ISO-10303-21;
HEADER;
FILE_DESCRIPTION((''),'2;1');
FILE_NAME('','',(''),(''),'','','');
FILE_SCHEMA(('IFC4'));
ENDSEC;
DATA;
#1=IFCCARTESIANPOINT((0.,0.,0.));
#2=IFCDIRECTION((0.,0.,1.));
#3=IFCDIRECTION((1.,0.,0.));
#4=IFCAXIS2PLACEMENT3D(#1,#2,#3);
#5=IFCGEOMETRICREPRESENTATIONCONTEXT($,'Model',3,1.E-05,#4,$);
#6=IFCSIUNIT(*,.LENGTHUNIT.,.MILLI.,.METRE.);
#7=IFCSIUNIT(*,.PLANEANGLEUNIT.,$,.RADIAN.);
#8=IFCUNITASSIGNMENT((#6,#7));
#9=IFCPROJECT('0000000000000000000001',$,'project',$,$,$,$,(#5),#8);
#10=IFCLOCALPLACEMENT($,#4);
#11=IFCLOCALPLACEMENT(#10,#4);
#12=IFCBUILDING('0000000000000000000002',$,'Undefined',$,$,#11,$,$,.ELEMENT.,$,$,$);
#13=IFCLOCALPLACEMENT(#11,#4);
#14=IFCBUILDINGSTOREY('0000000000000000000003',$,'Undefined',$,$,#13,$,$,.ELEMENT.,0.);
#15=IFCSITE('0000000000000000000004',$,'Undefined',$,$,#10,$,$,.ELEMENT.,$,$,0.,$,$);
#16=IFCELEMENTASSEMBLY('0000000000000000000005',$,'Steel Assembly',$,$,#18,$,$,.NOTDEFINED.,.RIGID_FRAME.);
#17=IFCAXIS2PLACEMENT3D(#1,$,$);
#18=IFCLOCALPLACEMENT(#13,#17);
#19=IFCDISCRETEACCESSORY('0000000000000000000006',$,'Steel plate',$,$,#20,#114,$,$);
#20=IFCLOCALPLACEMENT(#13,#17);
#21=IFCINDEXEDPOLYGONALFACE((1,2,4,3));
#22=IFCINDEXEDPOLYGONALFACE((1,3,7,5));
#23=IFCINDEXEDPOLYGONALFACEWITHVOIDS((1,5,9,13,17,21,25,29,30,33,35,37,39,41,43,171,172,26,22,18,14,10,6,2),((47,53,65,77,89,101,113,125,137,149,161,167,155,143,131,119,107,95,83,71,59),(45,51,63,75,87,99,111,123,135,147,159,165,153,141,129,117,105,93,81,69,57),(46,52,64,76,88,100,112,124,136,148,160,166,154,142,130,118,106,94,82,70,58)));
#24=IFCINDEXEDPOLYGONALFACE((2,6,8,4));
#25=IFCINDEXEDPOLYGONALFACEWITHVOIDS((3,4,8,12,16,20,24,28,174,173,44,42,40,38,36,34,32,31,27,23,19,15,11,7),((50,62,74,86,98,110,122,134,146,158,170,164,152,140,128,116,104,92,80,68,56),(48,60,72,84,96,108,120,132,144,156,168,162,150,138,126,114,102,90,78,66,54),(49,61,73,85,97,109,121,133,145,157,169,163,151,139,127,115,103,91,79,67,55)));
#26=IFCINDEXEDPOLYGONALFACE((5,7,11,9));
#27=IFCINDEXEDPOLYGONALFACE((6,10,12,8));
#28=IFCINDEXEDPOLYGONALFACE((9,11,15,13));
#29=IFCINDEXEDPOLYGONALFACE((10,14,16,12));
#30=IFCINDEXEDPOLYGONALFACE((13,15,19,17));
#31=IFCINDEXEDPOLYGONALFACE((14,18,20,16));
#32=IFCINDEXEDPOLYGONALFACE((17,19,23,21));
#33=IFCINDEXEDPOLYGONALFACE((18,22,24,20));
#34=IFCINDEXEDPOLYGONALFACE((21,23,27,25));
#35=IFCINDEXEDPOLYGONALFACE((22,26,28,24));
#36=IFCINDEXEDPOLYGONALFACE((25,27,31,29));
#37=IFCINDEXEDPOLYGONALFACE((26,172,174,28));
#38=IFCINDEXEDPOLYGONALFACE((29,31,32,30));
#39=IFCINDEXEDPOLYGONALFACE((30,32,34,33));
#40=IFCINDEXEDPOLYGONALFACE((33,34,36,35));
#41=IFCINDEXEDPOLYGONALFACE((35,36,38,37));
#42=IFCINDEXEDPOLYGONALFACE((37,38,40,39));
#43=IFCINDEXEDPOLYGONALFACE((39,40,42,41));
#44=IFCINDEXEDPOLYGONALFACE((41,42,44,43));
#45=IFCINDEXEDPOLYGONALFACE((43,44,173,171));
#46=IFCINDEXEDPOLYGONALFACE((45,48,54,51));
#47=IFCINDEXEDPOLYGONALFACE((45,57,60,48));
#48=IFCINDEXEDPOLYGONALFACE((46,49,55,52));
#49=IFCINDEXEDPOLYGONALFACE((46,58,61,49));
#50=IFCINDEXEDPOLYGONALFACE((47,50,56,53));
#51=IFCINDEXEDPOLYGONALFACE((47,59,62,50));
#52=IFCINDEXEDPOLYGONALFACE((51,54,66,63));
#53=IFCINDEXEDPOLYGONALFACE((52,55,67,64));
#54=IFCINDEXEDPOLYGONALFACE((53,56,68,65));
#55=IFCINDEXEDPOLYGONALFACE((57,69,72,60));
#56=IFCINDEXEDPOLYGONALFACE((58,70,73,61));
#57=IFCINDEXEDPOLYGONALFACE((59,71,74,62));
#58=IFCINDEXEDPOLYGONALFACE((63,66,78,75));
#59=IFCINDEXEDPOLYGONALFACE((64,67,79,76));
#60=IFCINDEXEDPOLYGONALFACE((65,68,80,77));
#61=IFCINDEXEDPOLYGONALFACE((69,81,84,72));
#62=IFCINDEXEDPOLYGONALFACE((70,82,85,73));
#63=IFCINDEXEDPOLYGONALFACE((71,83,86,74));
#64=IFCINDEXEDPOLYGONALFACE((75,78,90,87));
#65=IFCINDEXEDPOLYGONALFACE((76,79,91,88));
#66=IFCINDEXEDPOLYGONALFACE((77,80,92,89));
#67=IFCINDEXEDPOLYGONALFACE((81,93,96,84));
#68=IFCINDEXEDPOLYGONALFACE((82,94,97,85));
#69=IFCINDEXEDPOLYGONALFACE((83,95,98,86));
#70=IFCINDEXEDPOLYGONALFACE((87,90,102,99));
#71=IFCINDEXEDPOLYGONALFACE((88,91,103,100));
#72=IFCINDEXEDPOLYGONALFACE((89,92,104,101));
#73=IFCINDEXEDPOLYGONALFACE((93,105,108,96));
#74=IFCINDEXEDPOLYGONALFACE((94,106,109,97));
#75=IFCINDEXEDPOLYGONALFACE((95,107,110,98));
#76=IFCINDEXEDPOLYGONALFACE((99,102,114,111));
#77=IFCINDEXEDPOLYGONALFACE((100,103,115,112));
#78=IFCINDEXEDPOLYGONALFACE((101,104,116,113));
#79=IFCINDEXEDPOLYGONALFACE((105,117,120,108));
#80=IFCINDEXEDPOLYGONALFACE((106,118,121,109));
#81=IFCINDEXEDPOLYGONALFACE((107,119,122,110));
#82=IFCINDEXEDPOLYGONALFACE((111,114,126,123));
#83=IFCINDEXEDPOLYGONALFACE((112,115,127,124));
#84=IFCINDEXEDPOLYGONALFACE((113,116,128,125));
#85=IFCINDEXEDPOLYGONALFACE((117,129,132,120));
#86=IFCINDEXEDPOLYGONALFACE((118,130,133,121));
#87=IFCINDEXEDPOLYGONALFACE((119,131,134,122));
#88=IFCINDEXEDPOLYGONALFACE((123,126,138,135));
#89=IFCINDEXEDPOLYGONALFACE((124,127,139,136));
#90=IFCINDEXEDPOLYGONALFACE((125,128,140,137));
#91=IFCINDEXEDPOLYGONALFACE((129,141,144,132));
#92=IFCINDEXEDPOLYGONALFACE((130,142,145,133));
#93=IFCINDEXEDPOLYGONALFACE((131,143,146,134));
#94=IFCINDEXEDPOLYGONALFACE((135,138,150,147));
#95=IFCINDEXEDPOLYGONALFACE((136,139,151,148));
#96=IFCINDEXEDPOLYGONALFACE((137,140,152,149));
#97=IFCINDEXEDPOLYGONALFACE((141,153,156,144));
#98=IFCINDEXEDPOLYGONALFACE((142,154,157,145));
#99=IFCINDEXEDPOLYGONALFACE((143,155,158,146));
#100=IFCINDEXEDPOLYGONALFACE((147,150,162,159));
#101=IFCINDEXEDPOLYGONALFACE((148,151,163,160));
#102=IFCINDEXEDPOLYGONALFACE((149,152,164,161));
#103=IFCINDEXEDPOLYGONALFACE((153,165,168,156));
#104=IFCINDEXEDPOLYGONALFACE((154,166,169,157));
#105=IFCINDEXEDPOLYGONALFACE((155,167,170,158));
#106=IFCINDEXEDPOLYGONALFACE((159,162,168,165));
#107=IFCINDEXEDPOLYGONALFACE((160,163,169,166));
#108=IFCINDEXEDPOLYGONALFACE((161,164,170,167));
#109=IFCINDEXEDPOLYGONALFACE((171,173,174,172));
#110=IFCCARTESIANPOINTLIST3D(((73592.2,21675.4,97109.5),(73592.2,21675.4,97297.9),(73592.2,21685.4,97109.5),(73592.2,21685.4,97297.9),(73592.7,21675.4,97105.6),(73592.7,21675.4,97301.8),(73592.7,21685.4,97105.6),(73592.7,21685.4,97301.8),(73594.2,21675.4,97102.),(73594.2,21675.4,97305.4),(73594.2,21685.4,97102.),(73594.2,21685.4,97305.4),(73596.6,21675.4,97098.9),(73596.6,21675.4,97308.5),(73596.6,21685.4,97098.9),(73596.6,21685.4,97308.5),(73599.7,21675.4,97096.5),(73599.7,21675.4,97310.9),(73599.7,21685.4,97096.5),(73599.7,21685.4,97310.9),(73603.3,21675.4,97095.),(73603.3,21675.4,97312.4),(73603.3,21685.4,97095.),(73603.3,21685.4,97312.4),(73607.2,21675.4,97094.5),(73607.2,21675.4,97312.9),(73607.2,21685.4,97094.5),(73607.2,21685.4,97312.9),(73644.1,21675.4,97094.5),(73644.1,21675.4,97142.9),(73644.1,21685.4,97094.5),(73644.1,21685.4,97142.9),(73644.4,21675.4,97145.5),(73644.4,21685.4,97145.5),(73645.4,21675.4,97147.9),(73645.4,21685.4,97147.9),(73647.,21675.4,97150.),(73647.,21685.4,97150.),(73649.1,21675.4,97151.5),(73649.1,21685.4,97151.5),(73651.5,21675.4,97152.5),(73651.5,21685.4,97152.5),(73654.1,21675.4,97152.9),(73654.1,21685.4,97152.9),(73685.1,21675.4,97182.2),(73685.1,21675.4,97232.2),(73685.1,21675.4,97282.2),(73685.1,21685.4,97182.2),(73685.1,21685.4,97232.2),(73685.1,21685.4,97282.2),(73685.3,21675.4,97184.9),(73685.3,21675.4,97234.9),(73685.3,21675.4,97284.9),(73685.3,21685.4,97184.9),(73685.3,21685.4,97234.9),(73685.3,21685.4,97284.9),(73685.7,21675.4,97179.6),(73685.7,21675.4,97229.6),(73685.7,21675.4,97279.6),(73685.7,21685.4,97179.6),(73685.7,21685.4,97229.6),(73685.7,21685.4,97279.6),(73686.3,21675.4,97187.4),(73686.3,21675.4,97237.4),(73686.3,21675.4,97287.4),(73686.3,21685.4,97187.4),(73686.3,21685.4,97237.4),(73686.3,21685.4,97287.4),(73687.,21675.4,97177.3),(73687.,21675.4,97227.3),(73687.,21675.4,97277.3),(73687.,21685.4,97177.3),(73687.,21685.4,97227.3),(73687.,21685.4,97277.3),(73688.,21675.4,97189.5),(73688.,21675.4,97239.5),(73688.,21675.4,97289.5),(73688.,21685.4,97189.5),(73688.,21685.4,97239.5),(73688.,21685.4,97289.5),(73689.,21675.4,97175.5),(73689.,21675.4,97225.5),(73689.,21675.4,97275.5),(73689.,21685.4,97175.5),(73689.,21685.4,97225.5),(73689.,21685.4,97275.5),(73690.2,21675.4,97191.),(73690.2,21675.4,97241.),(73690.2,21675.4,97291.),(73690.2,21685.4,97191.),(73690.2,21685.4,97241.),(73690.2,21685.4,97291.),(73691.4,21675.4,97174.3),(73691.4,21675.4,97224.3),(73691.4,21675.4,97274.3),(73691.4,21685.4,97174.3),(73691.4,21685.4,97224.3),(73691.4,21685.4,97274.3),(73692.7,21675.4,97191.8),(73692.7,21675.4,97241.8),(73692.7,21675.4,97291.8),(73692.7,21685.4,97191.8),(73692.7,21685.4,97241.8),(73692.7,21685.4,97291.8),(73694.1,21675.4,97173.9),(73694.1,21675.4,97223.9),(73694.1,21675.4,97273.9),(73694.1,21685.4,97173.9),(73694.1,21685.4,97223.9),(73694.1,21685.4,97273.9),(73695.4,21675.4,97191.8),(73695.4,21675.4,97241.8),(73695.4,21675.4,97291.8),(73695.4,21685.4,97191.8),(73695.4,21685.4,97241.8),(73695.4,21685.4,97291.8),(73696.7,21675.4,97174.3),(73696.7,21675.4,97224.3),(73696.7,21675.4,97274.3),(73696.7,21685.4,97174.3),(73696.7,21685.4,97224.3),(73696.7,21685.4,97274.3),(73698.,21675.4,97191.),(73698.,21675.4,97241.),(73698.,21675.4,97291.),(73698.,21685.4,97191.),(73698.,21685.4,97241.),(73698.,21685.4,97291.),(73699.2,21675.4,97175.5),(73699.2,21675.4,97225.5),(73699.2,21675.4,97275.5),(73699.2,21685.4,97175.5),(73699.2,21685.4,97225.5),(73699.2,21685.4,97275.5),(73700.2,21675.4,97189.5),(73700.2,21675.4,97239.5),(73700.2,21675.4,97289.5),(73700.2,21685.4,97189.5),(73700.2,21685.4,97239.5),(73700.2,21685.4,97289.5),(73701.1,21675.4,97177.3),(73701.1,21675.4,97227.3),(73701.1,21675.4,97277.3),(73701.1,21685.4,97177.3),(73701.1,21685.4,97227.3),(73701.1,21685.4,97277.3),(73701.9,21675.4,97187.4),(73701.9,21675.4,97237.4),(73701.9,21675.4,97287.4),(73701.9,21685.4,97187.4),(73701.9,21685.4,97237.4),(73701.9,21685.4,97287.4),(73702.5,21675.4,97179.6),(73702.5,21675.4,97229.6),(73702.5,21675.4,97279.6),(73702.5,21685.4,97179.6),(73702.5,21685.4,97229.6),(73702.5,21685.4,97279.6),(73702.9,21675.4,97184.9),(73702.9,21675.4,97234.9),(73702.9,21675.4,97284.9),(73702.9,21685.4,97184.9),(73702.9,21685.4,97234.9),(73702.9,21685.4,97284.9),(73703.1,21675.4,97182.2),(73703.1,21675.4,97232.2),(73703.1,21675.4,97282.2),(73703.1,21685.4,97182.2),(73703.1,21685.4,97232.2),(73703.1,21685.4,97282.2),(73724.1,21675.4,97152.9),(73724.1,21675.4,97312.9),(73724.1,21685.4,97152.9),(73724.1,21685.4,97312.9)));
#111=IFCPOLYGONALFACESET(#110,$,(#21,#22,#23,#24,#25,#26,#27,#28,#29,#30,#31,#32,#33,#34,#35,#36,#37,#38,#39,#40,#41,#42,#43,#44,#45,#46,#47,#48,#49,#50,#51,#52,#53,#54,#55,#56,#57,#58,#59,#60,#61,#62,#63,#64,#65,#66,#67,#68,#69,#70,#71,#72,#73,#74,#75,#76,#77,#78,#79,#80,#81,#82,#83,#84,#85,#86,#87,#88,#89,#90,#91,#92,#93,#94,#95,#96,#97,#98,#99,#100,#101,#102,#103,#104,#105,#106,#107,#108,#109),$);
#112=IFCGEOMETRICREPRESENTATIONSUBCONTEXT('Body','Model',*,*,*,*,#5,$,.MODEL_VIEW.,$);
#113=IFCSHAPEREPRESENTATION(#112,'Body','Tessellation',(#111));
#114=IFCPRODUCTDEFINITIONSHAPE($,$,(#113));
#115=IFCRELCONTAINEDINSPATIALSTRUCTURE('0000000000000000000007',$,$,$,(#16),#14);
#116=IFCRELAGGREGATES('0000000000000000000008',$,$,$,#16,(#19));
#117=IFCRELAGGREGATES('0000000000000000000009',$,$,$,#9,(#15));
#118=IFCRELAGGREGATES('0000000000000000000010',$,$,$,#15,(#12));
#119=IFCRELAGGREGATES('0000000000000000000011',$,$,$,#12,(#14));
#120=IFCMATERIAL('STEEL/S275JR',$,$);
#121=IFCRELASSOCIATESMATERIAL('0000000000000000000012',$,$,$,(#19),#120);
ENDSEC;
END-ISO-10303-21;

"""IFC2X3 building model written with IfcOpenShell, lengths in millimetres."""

from ifc_helpers import new_model, si_unit, frame, frame_2d, origin_with_axes, origin_2d_with_axis, place, context, subcontext, project, spatial, polyline, circle_curve, parameter, trimmed, segment, composite_curve, circle, outline, extrude, source, transform, mapped, material, element, aggregate, save


model = new_model("IFC2X3")

# Units and contexts
model_context = context("Model", 3, precision=1e-05, world=origin_with_axes())
body_context = subcontext(model_context, "Body", "Model", "MODEL_VIEW")
ifc_project = project(units=[si_unit("LENGTHUNIT", "METRE", prefix="MILLI"), si_unit("PLANEANGLEUNIT", "RADIAN")], contexts=[model_context])

# Site, building, storey
site_placement = place(None, origin_with_axes())
site = spatial("IfcSite", under=ifc_project, at=site_placement, Name="Undefined", CompositionType="ELEMENT", RefElevation=0.0)
building_placement = place(site_placement, origin_with_axes())
building = spatial("IfcBuilding", under=site, at=building_placement, Name="Undefined", CompositionType="ELEMENT")
storey_placement = place(building_placement, origin_with_axes())
storey = spatial("IfcBuildingStorey", under=building, at=storey_placement, Name="Undefined", CompositionType="ELEMENT", Elevation=0.0)

# Element assembly
assembly_1_placement = place(storey_placement, origin_with_axes())
assembly_1 = element("IfcElementAssembly", 1, at=assembly_1_placement, inside=storey, Name="Steel Assembly", AssemblyPlace="NOTDEFINED", PredefinedType="RIGID_FRAME")
ifc_material_1 = material(Name="STEEL/S275JR")

# Discrete accessory, opening
discrete_accessory_1_placement = place(assembly_1_placement, frame((73592.2, 21680.4, 97312.9), z_axis=(0.0, 1.0, 0.0), x_axis=(1.0, 0.0, 0.0)))
discrete_accessory_1 = element("IfcDiscreteAccessory", 2, at=discrete_accessory_1_placement, material=ifc_material_1, Name="Steel plate", context=body_context, shape_type="SweptSolid", body=[
    extrude(outline(composite_curve([segment(trimmed(circle_curve(frame_2d((15.0, 15.0), x_axis=(-1.0, 0.0)), 15.0), [parameter(0.0)], [parameter(1.570796)], True, "PARAMETER"), True, "CONTINUOUS"), segment(polyline([(15.0, 0.0), (131.9, 0.0), (131.9, 160.0), (61.9, 160.0)]), True, "CONTINUOUS"), segment(trimmed(circle_curve(frame_2d((61.9, 170.0), x_axis=(0.0, -1.0)), 10.0), [parameter(0.0)], [parameter(4.712389)], False, "PARAMETER"), True, "CONTINUOUS"), segment(polyline([(51.9, 170.0), (51.9, 218.4), (15.0, 218.4)]), True, "CONTINUOUS"), segment(trimmed(circle_curve(frame_2d((15.0, 203.4), x_axis=(0.0, 1.0)), 15.0), [parameter(0.0)], [parameter(1.570796)], True, "PARAMETER"), True, "CONTINUOUS"), segment(polyline([(0.0, 203.4), (0.0, 15.0)]), True, "DISCONTINUOUS")], self_intersect=False)), frame((0.0, 0.0, -5.0), z_axis=(0.0, 0.0, 1.0), x_axis=(1.0, 0.0, 0.0)), (0.0, 0.0, 1.0), 10.0),
])
shared_shape_1 = source(origin_with_axes(), body_context, "Body", "SweptSolid", [
    extrude(circle(Radius=9.0, at=origin_2d_with_axis()), frame((0.0, -10.1, 0.0), z_axis=(0.0, 1.0, 0.0), x_axis=(1.0, 0.0, 0.0)), (0.0, 0.0, 1.0), 20.3),
])
opening_1_placement = place(assembly_1_placement, frame((73694.1, 21675.4, 97282.9), z_axis=(-1.0, 0.0, 0.0), x_axis=(0.0, 0.0, -1.0)))
element("IfcOpeningElement", 3, at=opening_1_placement, cuts=discrete_accessory_1, ObjectType="Opening", context=body_context, shape_type="MappedRepresentation", body=[
    mapped(shared_shape_1, transform((0.0, 0.0, 0.0))),
    mapped(shared_shape_1, transform((50.0, 0.0, 0.0))),
    mapped(shared_shape_1, transform((100.0, 0.0, 0.0))),
])
aggregate(assembly_1, [discrete_accessory_1])

save(model, "model.ifc")
